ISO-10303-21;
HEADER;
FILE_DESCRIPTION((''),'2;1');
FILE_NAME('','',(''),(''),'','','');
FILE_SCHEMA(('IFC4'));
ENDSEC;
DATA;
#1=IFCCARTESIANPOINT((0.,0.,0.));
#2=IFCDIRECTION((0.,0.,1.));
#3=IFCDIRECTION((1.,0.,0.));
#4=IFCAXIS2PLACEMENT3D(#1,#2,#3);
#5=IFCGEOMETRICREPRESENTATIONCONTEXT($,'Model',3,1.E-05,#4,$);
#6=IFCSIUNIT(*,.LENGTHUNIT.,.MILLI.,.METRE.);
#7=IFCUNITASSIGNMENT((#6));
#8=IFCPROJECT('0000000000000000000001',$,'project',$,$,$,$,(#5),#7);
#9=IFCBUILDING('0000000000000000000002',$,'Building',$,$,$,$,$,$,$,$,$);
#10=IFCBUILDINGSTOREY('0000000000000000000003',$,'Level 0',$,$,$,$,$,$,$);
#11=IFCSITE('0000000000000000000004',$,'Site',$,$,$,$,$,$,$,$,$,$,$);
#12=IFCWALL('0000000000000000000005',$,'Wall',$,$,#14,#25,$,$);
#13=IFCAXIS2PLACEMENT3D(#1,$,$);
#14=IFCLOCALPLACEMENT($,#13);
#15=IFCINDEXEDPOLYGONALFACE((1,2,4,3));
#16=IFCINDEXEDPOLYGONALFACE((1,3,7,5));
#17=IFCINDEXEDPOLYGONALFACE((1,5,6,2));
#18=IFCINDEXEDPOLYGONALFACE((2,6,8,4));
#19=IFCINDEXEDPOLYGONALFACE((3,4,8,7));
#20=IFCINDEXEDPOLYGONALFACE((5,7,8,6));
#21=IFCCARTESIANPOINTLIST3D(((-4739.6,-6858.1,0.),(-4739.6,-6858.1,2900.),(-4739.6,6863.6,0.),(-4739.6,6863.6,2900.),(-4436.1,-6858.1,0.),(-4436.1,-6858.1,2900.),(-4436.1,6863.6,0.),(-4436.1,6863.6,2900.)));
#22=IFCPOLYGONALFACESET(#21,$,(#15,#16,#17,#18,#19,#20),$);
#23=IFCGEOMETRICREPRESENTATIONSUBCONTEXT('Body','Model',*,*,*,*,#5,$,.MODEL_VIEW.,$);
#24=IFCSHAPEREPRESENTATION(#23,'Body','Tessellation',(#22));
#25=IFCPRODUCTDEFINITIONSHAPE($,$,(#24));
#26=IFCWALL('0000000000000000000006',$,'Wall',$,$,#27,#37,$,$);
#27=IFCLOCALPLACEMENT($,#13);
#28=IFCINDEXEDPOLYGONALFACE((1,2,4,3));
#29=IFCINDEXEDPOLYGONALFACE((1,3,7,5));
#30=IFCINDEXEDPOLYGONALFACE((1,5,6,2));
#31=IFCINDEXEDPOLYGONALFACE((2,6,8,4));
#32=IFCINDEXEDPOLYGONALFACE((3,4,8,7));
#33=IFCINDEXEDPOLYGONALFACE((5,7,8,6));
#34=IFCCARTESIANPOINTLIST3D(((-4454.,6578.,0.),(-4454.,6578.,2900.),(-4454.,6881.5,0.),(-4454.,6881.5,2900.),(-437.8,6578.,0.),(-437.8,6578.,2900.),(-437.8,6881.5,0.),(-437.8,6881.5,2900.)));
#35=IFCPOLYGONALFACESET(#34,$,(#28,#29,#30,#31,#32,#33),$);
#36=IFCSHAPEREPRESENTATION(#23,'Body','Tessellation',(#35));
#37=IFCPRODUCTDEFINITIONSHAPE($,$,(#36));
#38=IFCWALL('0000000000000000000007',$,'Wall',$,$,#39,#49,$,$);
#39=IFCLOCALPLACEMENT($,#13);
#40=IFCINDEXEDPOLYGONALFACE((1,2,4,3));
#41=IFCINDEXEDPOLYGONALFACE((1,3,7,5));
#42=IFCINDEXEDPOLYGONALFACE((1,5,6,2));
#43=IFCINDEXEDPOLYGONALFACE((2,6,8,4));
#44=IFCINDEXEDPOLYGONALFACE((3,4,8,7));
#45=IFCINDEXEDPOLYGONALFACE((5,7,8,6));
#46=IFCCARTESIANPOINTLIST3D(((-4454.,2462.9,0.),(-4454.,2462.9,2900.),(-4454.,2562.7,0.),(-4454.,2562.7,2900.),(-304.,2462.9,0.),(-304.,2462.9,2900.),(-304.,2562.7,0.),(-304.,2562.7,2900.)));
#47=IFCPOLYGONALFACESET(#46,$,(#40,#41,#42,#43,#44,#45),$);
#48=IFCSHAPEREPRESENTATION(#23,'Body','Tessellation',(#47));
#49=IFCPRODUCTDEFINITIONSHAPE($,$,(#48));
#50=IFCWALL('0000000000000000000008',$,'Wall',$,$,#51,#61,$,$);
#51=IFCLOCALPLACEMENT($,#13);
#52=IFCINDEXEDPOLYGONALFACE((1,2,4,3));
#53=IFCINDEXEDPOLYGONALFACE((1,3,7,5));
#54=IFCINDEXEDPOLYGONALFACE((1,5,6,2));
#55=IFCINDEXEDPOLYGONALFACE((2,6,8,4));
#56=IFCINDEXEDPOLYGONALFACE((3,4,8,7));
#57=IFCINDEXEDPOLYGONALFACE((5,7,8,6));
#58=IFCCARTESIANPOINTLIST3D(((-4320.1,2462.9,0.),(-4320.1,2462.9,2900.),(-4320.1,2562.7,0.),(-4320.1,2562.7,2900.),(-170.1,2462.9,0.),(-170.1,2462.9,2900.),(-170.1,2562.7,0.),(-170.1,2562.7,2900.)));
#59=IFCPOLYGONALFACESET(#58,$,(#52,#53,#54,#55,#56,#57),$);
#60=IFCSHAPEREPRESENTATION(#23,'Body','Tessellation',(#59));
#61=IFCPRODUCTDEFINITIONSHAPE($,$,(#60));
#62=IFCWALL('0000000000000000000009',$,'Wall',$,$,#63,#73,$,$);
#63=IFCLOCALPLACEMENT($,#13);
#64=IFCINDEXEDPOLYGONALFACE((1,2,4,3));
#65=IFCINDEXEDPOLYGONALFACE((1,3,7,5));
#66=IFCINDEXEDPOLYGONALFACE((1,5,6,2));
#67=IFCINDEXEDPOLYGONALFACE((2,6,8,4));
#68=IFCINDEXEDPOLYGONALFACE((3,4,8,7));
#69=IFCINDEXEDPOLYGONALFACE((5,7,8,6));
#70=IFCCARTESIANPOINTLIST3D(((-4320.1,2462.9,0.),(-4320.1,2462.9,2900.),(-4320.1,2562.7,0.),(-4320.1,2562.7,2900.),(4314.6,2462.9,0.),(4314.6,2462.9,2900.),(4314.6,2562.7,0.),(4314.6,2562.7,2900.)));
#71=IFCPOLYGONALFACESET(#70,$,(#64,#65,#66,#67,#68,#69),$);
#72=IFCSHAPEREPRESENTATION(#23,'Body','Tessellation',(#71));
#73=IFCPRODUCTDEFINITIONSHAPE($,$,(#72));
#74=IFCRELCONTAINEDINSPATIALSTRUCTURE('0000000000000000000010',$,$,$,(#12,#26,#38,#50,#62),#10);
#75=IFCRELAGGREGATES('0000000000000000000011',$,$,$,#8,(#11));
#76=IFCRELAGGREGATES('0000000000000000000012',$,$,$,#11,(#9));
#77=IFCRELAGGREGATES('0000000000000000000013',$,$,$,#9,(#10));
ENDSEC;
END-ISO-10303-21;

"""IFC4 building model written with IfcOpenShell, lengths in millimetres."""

from ifc_helpers import new_model, si_unit, frame, origin_with_axes, place, context, subcontext, project, spatial, indexed_curve, outline, extrude, element, save


model = new_model("IFC4")

# Units and contexts
model_context = context("Model", 3, precision=1e-05, world=origin_with_axes())
body_context = subcontext(model_context, "Body", "Model", "MODEL_VIEW")
ifc_project = project(units=[si_unit("LENGTHUNIT", "METRE", prefix="MILLI")], contexts=[model_context])

# Site, building, storey
site = spatial("IfcSite", under=ifc_project, Name="Site")
building = spatial("IfcBuilding", under=site, Name="Building")
storey = spatial("IfcBuildingStorey", under=building, Name="Level 0")

# Walls
wall_1_placement = place(None, frame((-4739.6, 6863.6, 0.0), z_axis=(0.0, 0.0, 1.0), x_axis=(0.0, -1.0, 0.0)))
element("IfcWall", 1, at=wall_1_placement, inside=storey, Name="Wall", context=body_context, shape_type="SweptSolid", body=[
    extrude(outline(indexed_curve([(0.0, 0.0), (0.0, 303.4), (13721.8, 303.4), (13721.8, 0.0), (0.0, 0.0)], self_intersect=False)), origin_with_axes(), (0.0, 0.0, 1.0), 2900.0),
])
wall_2_placement = place(None, frame((-4454.0, 6578.0, 0.0), z_axis=(0.0, 0.0, 1.0), x_axis=(1.0, 0.0, 0.0)))
element("IfcWall", 2, at=wall_2_placement, inside=storey, Name="Wall", context=body_context, shape_type="SweptSolid", body=[
    extrude(outline(indexed_curve([(0.0, 0.0), (0.0, 303.4), (4016.1, 303.4), (4016.1, 0.0), (0.0, 0.0)], self_intersect=False)), origin_with_axes(), (0.0, 0.0, 1.0), 2900.0),
])
for number, where, z_axis, x_axis, name in (
    (3, (-4454.0, 2462.9, 0.0), (0.0, 0.0, 1.0), (1.0, 0.0, 0.0), "Wall"),
):
    element("IfcWall", number, at=place(None, frame(where, z_axis=z_axis, x_axis=x_axis)), inside=storey, Name=name, context=body_context, shape_type="SweptSolid", body=[
        extrude(outline(indexed_curve([(0.0, 0.0), (0.0, 99.8), (4150.0, 99.8), (4150.0, 0.0), (0.0, 0.0)], self_intersect=False)), origin_with_axes(), (0.0, 0.0, 1.0), 2900.0),
    ])
for number, where, z_axis, x_axis, name in (
    (4, (-4320.1, 2462.9, 0.0), (0.0, 0.0, 1.0), (1.0, 0.0, 0.0), "Wall"),
):
    element("IfcWall", number, at=place(None, frame(where, z_axis=z_axis, x_axis=x_axis)), inside=storey, Name=name, context=body_context, shape_type="SweptSolid", body=[
        extrude(outline(indexed_curve([(0.0, 0.0), (0.0, 99.8), (4150.0, 99.8), (4150.0, 0.0), (0.0, 0.0)], self_intersect=False)), origin_with_axes(), (0.0, 0.0, 1.0), 2900.0),
    ])
wall_3_placement = place(None, frame((-4320.1, 2462.9, 0.0), z_axis=(0.0, 0.0, 1.0), x_axis=(1.0, 0.0, 0.0)))
element("IfcWall", 5, at=wall_3_placement, inside=storey, Name="Wall", context=body_context, shape_type="SweptSolid", body=[
    extrude(outline(indexed_curve([(0.0, 0.0), (0.0, 99.8), (8634.7, 99.8), (8634.7, 0.0), (0.0, 0.0)], self_intersect=False)), origin_with_axes(), (0.0, 0.0, 1.0), 2900.0),
])

save(model, "model.ifc")
